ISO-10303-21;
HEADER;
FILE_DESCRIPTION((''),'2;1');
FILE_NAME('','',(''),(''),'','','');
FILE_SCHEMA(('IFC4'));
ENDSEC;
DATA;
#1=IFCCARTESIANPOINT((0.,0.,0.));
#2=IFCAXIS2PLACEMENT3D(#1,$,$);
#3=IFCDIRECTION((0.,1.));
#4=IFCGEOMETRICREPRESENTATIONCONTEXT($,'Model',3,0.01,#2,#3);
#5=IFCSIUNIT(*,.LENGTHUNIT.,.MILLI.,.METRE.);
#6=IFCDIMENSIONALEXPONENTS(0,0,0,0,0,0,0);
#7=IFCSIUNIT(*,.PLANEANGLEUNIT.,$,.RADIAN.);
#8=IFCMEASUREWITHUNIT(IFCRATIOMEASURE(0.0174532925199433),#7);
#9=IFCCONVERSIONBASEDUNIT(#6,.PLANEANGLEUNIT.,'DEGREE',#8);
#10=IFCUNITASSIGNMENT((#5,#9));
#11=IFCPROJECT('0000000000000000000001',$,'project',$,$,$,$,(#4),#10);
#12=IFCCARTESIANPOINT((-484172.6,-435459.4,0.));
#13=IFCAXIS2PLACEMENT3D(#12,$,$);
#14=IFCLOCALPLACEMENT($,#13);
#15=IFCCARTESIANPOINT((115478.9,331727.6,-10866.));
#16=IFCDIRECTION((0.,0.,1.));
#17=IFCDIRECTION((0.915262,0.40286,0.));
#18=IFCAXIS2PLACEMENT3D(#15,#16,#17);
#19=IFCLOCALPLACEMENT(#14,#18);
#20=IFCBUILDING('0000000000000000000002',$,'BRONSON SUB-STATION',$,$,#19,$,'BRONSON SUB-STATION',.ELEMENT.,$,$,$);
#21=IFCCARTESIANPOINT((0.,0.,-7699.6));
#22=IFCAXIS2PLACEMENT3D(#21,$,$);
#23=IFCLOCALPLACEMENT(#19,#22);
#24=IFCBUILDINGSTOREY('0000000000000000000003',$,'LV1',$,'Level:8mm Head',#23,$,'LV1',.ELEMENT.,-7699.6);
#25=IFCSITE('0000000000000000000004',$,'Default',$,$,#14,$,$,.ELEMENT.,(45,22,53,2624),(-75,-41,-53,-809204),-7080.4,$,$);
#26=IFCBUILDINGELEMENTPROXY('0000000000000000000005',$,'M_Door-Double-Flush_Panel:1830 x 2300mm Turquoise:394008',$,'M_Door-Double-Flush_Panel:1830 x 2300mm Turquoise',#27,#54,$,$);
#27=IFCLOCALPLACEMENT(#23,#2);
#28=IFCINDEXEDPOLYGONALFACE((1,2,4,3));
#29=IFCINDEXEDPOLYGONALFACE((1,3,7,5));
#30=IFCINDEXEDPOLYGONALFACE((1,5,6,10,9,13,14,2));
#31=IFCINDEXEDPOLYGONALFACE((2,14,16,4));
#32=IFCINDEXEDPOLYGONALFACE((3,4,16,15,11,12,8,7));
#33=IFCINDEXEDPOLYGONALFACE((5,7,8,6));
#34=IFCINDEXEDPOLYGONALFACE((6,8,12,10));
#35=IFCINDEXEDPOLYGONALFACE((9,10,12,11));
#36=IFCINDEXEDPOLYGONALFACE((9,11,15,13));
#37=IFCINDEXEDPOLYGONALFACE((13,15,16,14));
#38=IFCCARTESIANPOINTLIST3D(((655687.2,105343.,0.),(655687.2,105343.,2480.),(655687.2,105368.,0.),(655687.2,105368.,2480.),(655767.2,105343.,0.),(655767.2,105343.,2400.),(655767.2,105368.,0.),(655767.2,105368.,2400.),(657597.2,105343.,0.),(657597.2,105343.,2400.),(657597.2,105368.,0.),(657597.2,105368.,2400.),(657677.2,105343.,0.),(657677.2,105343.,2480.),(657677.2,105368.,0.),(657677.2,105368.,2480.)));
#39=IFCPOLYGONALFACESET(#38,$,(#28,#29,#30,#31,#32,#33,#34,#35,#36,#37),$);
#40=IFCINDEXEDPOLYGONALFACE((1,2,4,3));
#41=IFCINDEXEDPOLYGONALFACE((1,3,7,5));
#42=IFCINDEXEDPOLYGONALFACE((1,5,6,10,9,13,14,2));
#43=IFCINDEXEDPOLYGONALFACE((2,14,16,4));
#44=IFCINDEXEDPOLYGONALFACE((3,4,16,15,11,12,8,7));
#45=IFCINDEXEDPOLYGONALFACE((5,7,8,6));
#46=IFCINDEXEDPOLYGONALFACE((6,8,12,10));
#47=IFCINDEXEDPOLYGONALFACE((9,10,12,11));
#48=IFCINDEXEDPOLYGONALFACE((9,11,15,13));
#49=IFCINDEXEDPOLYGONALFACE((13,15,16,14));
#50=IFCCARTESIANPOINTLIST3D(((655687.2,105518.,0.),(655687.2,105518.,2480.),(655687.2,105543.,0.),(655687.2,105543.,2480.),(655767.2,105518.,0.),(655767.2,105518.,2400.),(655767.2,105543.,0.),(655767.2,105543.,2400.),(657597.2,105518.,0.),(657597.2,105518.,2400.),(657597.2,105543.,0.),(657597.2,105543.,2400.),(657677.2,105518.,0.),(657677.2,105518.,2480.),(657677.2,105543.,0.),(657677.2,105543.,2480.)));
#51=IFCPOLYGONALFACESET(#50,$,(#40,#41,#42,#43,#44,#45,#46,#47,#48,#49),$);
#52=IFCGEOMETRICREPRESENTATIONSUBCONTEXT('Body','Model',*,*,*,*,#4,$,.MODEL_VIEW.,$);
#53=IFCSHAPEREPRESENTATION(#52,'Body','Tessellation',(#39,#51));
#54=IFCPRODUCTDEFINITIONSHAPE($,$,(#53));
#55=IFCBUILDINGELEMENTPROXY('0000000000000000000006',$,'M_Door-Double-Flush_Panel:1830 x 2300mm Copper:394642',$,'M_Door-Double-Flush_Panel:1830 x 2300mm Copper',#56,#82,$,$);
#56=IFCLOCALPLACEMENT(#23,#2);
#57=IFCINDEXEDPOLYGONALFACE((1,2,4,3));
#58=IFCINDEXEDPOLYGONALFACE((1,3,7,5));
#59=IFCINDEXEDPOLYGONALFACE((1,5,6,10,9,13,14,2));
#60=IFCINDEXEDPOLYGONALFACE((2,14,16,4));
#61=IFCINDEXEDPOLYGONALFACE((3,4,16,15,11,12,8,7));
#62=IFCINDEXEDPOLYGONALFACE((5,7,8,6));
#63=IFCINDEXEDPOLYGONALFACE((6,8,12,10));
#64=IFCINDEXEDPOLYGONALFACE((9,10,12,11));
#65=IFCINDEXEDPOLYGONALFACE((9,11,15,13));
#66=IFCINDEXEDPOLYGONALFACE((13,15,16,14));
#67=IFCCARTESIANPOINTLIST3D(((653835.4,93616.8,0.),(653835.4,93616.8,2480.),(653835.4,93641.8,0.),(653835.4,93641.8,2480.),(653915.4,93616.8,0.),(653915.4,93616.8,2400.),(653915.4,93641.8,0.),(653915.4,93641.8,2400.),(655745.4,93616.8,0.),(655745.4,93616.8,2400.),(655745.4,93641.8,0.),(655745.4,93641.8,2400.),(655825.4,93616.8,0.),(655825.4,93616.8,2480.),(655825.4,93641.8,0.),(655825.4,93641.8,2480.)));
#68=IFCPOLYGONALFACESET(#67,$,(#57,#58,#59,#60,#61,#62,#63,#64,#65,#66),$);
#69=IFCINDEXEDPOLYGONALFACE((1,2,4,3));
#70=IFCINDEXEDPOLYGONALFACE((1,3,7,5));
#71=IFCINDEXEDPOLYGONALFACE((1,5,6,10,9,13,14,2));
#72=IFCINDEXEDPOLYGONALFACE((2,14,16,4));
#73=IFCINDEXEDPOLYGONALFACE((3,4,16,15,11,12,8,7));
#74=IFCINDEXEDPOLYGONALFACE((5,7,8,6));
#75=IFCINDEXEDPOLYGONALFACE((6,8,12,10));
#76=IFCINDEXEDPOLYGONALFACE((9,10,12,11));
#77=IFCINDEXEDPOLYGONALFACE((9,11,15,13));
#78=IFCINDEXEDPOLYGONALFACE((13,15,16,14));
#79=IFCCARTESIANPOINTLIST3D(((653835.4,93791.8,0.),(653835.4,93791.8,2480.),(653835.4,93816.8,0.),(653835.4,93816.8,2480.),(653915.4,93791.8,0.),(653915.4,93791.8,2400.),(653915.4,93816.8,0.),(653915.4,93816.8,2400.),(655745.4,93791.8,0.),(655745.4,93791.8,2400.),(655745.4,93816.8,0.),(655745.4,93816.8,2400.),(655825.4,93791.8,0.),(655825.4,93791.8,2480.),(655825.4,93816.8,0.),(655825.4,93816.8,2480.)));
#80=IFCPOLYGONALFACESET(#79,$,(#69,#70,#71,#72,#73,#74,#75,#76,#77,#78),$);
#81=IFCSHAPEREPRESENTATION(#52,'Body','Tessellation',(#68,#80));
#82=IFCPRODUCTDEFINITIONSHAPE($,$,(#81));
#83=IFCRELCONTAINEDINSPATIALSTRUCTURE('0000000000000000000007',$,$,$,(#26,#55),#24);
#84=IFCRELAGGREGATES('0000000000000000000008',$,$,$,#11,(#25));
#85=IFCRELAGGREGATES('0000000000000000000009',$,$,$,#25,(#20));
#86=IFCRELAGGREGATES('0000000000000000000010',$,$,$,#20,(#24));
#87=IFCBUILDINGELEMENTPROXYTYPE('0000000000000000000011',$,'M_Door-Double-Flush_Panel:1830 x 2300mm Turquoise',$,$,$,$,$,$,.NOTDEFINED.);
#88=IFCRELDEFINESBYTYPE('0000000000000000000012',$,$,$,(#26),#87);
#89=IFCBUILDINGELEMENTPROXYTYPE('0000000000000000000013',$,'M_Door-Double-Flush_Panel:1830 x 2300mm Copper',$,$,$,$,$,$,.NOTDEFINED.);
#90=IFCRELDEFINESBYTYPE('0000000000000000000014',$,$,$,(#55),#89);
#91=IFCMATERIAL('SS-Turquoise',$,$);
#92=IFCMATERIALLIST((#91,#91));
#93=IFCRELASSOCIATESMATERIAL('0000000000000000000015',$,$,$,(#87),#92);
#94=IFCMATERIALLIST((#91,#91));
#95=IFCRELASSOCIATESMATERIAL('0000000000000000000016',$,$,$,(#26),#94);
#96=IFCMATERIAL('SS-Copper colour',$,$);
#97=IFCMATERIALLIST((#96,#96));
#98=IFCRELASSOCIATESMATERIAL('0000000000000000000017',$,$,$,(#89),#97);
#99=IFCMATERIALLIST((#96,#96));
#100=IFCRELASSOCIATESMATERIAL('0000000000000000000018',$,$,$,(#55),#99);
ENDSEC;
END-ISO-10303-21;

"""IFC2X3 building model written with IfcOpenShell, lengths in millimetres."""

from ifc_helpers import new_model, entity, si_unit, converted_unit, direction, frame, origin, place, context, subcontext, project, spatial, polyline, outline, extrude, source, transform, mapped, material, material_list, type_object, type_shapes, element, save


model = new_model("IFC2X3")

# Units and contexts
model_context = context("Model", 3, precision=0.01, world=origin(), true_north=direction((0.0, 1.0)))
body_context = subcontext(model_context, "Body", "Model", "MODEL_VIEW")
ifc_project = project(units=[si_unit("LENGTHUNIT", "METRE", prefix="MILLI"), converted_unit("PLANEANGLEUNIT", "DEGREE", entity("IfcRatioMeasure", 0.0174532925199433), si_unit("PLANEANGLEUNIT", "RADIAN"), dimensions=[0, 0, 0, 0, 0, 0, 0])], contexts=[model_context])

# Site, building, storey
site_placement = place(None, frame((-484172.6, -435459.4, 0.0)))
site = spatial("IfcSite", under=ifc_project, at=site_placement, Name="Default", CompositionType="ELEMENT", RefLatitude=(45, 22, 53, 2624), RefLongitude=(-75, -41, -53, -809204), RefElevation=-7080.4)
building_placement = place(site_placement, frame((115478.9, 331727.6, -10866.0), z_axis=(0.0, 0.0, 1.0), x_axis=(0.915262, 0.40286, 0.0)))
building = spatial("IfcBuilding", under=site, at=building_placement, Name="BRONSON SUB-STATION", LongName="BRONSON SUB-STATION", CompositionType="ELEMENT")
storey_placement = place(building_placement, frame((0.0, 0.0, -7699.6)))
storey = spatial("IfcBuildingStorey", under=building, at=storey_placement, Name="LV1", ObjectType="Level:8mm Head", LongName="LV1", CompositionType="ELEMENT", Elevation=-7699.6)

# Shared definitions
ifc_material_1 = material(Name="SS-Copper colour")

# Building element proxies
ifc_material_2 = material(Name="SS-Turquoise")
ifc_material_list_1 = material_list([ifc_material_2, ifc_material_2])
ifc_material_list_2 = material_list([ifc_material_2, ifc_material_2])
building_element_proxy_type_1 = type_object("IfcBuildingElementProxyType", Name="M_Door-Double-Flush_Panel:1830 x 2300mm Turquoise", PredefinedType="NOTDEFINED", material=ifc_material_list_2)
shared_shape_1 = source(origin(), body_context, "Body", "SweptSolid", [
    extrude(outline(polyline([(-1180.0, 915.0), (1220.0, 915.0), (1220.0, 995.0), (-1260.0, 995.0), (-1260.0, -995.0), (1220.0, -995.0), (1220.0, -915.0), (-1180.0, -915.0), (-1180.0, 915.0)])), frame((0.0, 75.0, 1220.0), z_axis=(0.0, 1.0, 0.0), x_axis=(0.0, 0.0, -1.0)), (0.0, 0.0, 1.0), 25.0),
    extrude(outline(polyline([(-1180.0, 915.0), (1220.0, 915.0), (1220.0, 995.0), (-1260.0, 995.0), (-1260.0, -995.0), (1220.0, -995.0), (1220.0, -915.0), (-1180.0, -915.0), (-1180.0, 915.0)])), frame((0.0, -100.0, 1220.0), z_axis=(0.0, 1.0, 0.0), x_axis=(0.0, 0.0, -1.0)), (0.0, 0.0, 1.0), 25.0),
])
type_shapes(building_element_proxy_type_1, [shared_shape_1])
proxy_1_placement = place(storey_placement, frame((656682.2, 105443.0, 0.0), z_axis=(0.0, 0.0, 1.0), x_axis=(-1.0, 0.0, 0.0)))
element("IfcBuildingElementProxy", 1, at=proxy_1_placement, inside=storey, type_object=building_element_proxy_type_1, material=ifc_material_list_1, Name="M_Door-Double-Flush_Panel:1830 x 2300mm Turquoise:394008", ObjectType="M_Door-Double-Flush_Panel:1830 x 2300mm Turquoise", context=body_context, shape_type="MappedRepresentation", body=[
    mapped(shared_shape_1, transform((0.0, 0.0, 0.0), scale=1.0)),
])
ifc_material_list_3 = material_list([ifc_material_1, ifc_material_1])
ifc_material_list_4 = material_list([ifc_material_1, ifc_material_1])
building_element_proxy_type_2 = type_object("IfcBuildingElementProxyType", Name="M_Door-Double-Flush_Panel:1830 x 2300mm Copper", PredefinedType="NOTDEFINED", material=ifc_material_list_4)
shared_shape_2 = source(origin(), body_context, "Body", "SweptSolid", [
    extrude(outline(polyline([(-1180.0, 915.0), (1220.0, 915.0), (1220.0, 995.0), (-1260.0, 995.0), (-1260.0, -995.0), (1220.0, -995.0), (1220.0, -915.0), (-1180.0, -915.0), (-1180.0, 915.0)])), frame((0.0, -100.0, 1220.0), z_axis=(0.0, 1.0, 0.0), x_axis=(0.0, 0.0, -1.0)), (0.0, 0.0, 1.0), 25.0),
    extrude(outline(polyline([(-1180.0, 915.0), (1220.0, 915.0), (1220.0, 995.0), (-1260.0, 995.0), (-1260.0, -995.0), (1220.0, -995.0), (1220.0, -915.0), (-1180.0, -915.0), (-1180.0, 915.0)])), frame((0.0, 75.0, 1220.0), z_axis=(0.0, 1.0, 0.0), x_axis=(0.0, 0.0, -1.0)), (0.0, 0.0, 1.0), 25.0),
])
type_shapes(building_element_proxy_type_2, [shared_shape_2])
proxy_2_placement = place(storey_placement, frame((654830.4, 93716.8, 0.0)))
element("IfcBuildingElementProxy", 2, at=proxy_2_placement, inside=storey, type_object=building_element_proxy_type_2, material=ifc_material_list_3, Name="M_Door-Double-Flush_Panel:1830 x 2300mm Copper:394642", ObjectType="M_Door-Double-Flush_Panel:1830 x 2300mm Copper", context=body_context, shape_type="MappedRepresentation", body=[
    mapped(shared_shape_2, transform((0.0, 0.0, 0.0), scale=1.0)),
])

save(model, "model.ifc")
